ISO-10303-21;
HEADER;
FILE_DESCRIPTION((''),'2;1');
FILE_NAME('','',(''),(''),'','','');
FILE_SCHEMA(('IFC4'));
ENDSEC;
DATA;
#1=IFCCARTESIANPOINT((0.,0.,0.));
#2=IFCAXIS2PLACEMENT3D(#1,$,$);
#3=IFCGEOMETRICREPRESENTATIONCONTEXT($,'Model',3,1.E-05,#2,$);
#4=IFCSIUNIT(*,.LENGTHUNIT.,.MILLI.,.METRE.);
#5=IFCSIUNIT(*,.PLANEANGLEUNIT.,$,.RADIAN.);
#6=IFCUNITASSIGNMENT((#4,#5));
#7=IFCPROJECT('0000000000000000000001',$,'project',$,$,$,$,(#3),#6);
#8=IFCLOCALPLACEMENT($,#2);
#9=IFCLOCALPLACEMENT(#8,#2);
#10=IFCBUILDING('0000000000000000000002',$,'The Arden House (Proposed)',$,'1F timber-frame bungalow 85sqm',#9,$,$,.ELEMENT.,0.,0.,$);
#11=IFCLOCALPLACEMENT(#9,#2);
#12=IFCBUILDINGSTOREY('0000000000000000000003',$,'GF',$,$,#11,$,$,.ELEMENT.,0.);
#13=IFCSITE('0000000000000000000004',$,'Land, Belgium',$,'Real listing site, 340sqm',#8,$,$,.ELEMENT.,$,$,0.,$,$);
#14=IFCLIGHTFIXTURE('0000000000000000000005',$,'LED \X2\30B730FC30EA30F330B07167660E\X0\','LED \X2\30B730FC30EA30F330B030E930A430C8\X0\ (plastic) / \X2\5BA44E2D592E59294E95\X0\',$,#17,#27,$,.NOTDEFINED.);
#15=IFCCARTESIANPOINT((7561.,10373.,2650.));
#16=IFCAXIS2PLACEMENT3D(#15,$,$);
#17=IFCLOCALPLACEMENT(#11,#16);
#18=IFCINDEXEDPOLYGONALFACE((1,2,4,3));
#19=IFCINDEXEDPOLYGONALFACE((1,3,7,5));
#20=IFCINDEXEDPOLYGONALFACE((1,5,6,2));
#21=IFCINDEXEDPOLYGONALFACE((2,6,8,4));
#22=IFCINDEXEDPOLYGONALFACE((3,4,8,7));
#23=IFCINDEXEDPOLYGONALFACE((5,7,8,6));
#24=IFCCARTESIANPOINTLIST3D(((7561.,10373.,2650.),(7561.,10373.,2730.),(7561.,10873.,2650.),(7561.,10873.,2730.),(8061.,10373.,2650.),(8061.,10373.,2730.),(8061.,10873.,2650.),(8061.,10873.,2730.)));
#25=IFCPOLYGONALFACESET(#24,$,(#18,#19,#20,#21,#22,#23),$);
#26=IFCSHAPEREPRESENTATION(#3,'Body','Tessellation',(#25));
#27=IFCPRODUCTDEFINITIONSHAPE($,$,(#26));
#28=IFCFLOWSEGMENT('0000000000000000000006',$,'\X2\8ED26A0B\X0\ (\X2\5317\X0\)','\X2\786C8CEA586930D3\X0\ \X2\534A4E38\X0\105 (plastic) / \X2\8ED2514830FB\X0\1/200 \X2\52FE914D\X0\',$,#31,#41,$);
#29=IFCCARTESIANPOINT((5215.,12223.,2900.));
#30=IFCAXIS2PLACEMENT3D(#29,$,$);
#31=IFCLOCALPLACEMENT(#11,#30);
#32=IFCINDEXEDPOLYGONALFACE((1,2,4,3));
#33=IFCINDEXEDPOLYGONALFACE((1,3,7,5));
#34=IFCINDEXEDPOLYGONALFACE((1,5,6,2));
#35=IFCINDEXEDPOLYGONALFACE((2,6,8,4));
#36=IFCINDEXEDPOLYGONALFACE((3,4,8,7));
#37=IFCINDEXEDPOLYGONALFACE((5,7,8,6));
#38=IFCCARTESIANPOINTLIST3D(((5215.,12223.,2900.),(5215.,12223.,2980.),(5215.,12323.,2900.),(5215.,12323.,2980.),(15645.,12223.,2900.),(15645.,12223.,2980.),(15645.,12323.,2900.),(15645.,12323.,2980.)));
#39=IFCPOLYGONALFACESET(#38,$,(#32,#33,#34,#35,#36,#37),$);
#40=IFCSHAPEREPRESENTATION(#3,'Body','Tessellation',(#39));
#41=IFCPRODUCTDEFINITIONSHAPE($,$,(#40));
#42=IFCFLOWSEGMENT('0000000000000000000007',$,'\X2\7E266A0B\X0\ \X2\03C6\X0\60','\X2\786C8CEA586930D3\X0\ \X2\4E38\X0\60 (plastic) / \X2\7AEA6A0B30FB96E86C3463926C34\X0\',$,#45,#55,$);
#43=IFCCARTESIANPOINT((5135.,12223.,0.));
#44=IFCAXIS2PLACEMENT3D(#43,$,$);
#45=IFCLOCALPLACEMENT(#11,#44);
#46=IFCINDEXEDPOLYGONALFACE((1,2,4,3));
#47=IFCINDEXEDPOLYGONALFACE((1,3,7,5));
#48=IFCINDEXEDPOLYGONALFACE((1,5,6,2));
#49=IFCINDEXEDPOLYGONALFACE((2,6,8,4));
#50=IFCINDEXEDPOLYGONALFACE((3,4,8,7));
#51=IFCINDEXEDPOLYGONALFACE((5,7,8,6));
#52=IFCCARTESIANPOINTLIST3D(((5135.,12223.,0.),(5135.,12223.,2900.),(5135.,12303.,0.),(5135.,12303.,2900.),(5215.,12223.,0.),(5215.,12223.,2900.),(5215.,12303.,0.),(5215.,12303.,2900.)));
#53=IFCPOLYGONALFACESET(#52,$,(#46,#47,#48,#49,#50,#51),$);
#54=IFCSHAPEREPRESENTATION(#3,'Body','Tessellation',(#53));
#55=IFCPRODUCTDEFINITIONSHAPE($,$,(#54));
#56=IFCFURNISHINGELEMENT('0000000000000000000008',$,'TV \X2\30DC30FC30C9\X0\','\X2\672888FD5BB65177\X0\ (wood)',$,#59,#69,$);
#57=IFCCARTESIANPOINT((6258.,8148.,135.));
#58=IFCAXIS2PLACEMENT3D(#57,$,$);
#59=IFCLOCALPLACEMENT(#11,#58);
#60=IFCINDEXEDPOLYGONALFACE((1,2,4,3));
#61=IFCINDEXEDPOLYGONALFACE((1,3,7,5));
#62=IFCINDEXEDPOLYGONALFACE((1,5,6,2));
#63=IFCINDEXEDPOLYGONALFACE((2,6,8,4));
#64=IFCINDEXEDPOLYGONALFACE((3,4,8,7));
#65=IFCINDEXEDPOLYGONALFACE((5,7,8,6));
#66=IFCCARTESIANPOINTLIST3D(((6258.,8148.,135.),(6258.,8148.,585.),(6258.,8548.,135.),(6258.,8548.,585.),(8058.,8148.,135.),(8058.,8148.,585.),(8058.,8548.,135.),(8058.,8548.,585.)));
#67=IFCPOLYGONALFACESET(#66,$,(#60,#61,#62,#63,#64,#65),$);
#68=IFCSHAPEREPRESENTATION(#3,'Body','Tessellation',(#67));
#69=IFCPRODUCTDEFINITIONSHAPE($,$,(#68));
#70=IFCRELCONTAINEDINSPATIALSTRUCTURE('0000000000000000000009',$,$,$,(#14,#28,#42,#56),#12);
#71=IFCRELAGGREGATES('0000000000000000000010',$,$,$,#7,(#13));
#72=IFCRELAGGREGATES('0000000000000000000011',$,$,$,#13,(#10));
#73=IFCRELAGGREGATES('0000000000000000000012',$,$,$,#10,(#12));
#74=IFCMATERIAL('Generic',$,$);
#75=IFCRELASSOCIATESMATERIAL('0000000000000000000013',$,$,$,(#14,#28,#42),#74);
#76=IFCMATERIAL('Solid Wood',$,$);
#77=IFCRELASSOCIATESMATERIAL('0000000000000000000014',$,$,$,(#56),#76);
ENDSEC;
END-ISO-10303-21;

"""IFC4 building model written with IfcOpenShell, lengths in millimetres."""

from ifc_helpers import new_model, si_unit, frame, frame_2d, origin, place, context, project, spatial, rectangle, extrude, material, element, save


model = new_model("IFC4")

# Units and contexts
model_context = context("Model", 3, precision=1e-05, world=origin())
ifc_project = project(units=[si_unit("LENGTHUNIT", "METRE", prefix="MILLI"), si_unit("PLANEANGLEUNIT", "RADIAN")], contexts=[model_context])

# Site, building, storey
site_placement = place(None, origin())
site = spatial("IfcSite", under=ifc_project, at=site_placement, Name="Land, Belgium", ObjectType="Real listing site, 340sqm", CompositionType="ELEMENT", RefElevation=0.0)
building_placement = place(site_placement, origin())
building = spatial("IfcBuilding", under=site, at=building_placement, Name="The Arden House (Proposed)", ObjectType="1F timber-frame bungalow 85sqm", CompositionType="ELEMENT", ElevationOfRefHeight=0.0, ElevationOfTerrain=0.0)
storey_placement = place(building_placement, origin())
storey = spatial("IfcBuildingStorey", under=building, at=storey_placement, Name="GF", CompositionType="ELEMENT", Elevation=0.0)

# Shared definitions
ifc_material_1 = material(Name="Solid Wood")

# Shared definitions
ifc_material_2 = material(Name="Generic")

# Light fixture
light_fixture_placement = place(storey_placement, frame((7561.0, 10373.0, 2650.0)))
element("IfcLightFixture", 1, at=light_fixture_placement, inside=storey, material=ifc_material_2, Name="LED シーリング照明", Description="LED シーリングライト (plastic) / 室中央天井", PredefinedType="NOTDEFINED", context=model_context, shape_type="SweptSolid", body=[
    extrude(rectangle(XDim=500.0, YDim=500.0, at=frame_2d((250.0, 250.0))), frame((7561.0, 10373.0, 2650.0)), (0.0, 0.0, 1.0), 80.0),
])

# Flow segments
flow_segment_1_placement = place(storey_placement, frame((5215.0, 12223.0, 2900.0)))
element("IfcFlowSegment", 2, at=flow_segment_1_placement, inside=storey, material=ifc_material_2, Name="軒樋 (北)", Description="硬質塩ビ 半丸105 (plastic) / 軒先・1/200 勾配", context=model_context, shape_type="SweptSolid", body=[
    extrude(rectangle(XDim=10430.0, YDim=100.0, at=frame_2d((5215.0, 50.0))), frame((5215.0, 12223.0, 2900.0)), (0.0, 0.0, 1.0), 80.0),
])
flow_segment_2_placement = place(storey_placement, frame((5135.0, 12223.0, 0.0)))
element("IfcFlowSegment", 3, at=flow_segment_2_placement, inside=storey, material=ifc_material_2, Name="縦樋 φ60", Description="硬質塩ビ 丸60 (plastic) / 竪樋・雨水排水", context=model_context, shape_type="SweptSolid", body=[
    extrude(rectangle(XDim=80.0, YDim=80.0, at=frame_2d((40.0, 40.0))), frame((5135.0, 12223.0, 0.0)), (0.0, 0.0, 1.0), 2900.0),
])

# Furnishing element
furnishing_placement = place(storey_placement, frame((6258.0, 8148.0, 135.0)))
element("IfcFurnishingElement", 4, at=furnishing_placement, inside=storey, material=ifc_material_1, Name="TV ボード", Description="木製家具 (wood)", context=model_context, shape_type="SweptSolid", body=[
    extrude(rectangle(XDim=1800.0, YDim=400.0, at=frame_2d((900.0, 200.0))), frame((6258.0, 8148.0, 135.0)), (0.0, 0.0, 1.0), 450.0),
])

save(model, "model.ifc")
